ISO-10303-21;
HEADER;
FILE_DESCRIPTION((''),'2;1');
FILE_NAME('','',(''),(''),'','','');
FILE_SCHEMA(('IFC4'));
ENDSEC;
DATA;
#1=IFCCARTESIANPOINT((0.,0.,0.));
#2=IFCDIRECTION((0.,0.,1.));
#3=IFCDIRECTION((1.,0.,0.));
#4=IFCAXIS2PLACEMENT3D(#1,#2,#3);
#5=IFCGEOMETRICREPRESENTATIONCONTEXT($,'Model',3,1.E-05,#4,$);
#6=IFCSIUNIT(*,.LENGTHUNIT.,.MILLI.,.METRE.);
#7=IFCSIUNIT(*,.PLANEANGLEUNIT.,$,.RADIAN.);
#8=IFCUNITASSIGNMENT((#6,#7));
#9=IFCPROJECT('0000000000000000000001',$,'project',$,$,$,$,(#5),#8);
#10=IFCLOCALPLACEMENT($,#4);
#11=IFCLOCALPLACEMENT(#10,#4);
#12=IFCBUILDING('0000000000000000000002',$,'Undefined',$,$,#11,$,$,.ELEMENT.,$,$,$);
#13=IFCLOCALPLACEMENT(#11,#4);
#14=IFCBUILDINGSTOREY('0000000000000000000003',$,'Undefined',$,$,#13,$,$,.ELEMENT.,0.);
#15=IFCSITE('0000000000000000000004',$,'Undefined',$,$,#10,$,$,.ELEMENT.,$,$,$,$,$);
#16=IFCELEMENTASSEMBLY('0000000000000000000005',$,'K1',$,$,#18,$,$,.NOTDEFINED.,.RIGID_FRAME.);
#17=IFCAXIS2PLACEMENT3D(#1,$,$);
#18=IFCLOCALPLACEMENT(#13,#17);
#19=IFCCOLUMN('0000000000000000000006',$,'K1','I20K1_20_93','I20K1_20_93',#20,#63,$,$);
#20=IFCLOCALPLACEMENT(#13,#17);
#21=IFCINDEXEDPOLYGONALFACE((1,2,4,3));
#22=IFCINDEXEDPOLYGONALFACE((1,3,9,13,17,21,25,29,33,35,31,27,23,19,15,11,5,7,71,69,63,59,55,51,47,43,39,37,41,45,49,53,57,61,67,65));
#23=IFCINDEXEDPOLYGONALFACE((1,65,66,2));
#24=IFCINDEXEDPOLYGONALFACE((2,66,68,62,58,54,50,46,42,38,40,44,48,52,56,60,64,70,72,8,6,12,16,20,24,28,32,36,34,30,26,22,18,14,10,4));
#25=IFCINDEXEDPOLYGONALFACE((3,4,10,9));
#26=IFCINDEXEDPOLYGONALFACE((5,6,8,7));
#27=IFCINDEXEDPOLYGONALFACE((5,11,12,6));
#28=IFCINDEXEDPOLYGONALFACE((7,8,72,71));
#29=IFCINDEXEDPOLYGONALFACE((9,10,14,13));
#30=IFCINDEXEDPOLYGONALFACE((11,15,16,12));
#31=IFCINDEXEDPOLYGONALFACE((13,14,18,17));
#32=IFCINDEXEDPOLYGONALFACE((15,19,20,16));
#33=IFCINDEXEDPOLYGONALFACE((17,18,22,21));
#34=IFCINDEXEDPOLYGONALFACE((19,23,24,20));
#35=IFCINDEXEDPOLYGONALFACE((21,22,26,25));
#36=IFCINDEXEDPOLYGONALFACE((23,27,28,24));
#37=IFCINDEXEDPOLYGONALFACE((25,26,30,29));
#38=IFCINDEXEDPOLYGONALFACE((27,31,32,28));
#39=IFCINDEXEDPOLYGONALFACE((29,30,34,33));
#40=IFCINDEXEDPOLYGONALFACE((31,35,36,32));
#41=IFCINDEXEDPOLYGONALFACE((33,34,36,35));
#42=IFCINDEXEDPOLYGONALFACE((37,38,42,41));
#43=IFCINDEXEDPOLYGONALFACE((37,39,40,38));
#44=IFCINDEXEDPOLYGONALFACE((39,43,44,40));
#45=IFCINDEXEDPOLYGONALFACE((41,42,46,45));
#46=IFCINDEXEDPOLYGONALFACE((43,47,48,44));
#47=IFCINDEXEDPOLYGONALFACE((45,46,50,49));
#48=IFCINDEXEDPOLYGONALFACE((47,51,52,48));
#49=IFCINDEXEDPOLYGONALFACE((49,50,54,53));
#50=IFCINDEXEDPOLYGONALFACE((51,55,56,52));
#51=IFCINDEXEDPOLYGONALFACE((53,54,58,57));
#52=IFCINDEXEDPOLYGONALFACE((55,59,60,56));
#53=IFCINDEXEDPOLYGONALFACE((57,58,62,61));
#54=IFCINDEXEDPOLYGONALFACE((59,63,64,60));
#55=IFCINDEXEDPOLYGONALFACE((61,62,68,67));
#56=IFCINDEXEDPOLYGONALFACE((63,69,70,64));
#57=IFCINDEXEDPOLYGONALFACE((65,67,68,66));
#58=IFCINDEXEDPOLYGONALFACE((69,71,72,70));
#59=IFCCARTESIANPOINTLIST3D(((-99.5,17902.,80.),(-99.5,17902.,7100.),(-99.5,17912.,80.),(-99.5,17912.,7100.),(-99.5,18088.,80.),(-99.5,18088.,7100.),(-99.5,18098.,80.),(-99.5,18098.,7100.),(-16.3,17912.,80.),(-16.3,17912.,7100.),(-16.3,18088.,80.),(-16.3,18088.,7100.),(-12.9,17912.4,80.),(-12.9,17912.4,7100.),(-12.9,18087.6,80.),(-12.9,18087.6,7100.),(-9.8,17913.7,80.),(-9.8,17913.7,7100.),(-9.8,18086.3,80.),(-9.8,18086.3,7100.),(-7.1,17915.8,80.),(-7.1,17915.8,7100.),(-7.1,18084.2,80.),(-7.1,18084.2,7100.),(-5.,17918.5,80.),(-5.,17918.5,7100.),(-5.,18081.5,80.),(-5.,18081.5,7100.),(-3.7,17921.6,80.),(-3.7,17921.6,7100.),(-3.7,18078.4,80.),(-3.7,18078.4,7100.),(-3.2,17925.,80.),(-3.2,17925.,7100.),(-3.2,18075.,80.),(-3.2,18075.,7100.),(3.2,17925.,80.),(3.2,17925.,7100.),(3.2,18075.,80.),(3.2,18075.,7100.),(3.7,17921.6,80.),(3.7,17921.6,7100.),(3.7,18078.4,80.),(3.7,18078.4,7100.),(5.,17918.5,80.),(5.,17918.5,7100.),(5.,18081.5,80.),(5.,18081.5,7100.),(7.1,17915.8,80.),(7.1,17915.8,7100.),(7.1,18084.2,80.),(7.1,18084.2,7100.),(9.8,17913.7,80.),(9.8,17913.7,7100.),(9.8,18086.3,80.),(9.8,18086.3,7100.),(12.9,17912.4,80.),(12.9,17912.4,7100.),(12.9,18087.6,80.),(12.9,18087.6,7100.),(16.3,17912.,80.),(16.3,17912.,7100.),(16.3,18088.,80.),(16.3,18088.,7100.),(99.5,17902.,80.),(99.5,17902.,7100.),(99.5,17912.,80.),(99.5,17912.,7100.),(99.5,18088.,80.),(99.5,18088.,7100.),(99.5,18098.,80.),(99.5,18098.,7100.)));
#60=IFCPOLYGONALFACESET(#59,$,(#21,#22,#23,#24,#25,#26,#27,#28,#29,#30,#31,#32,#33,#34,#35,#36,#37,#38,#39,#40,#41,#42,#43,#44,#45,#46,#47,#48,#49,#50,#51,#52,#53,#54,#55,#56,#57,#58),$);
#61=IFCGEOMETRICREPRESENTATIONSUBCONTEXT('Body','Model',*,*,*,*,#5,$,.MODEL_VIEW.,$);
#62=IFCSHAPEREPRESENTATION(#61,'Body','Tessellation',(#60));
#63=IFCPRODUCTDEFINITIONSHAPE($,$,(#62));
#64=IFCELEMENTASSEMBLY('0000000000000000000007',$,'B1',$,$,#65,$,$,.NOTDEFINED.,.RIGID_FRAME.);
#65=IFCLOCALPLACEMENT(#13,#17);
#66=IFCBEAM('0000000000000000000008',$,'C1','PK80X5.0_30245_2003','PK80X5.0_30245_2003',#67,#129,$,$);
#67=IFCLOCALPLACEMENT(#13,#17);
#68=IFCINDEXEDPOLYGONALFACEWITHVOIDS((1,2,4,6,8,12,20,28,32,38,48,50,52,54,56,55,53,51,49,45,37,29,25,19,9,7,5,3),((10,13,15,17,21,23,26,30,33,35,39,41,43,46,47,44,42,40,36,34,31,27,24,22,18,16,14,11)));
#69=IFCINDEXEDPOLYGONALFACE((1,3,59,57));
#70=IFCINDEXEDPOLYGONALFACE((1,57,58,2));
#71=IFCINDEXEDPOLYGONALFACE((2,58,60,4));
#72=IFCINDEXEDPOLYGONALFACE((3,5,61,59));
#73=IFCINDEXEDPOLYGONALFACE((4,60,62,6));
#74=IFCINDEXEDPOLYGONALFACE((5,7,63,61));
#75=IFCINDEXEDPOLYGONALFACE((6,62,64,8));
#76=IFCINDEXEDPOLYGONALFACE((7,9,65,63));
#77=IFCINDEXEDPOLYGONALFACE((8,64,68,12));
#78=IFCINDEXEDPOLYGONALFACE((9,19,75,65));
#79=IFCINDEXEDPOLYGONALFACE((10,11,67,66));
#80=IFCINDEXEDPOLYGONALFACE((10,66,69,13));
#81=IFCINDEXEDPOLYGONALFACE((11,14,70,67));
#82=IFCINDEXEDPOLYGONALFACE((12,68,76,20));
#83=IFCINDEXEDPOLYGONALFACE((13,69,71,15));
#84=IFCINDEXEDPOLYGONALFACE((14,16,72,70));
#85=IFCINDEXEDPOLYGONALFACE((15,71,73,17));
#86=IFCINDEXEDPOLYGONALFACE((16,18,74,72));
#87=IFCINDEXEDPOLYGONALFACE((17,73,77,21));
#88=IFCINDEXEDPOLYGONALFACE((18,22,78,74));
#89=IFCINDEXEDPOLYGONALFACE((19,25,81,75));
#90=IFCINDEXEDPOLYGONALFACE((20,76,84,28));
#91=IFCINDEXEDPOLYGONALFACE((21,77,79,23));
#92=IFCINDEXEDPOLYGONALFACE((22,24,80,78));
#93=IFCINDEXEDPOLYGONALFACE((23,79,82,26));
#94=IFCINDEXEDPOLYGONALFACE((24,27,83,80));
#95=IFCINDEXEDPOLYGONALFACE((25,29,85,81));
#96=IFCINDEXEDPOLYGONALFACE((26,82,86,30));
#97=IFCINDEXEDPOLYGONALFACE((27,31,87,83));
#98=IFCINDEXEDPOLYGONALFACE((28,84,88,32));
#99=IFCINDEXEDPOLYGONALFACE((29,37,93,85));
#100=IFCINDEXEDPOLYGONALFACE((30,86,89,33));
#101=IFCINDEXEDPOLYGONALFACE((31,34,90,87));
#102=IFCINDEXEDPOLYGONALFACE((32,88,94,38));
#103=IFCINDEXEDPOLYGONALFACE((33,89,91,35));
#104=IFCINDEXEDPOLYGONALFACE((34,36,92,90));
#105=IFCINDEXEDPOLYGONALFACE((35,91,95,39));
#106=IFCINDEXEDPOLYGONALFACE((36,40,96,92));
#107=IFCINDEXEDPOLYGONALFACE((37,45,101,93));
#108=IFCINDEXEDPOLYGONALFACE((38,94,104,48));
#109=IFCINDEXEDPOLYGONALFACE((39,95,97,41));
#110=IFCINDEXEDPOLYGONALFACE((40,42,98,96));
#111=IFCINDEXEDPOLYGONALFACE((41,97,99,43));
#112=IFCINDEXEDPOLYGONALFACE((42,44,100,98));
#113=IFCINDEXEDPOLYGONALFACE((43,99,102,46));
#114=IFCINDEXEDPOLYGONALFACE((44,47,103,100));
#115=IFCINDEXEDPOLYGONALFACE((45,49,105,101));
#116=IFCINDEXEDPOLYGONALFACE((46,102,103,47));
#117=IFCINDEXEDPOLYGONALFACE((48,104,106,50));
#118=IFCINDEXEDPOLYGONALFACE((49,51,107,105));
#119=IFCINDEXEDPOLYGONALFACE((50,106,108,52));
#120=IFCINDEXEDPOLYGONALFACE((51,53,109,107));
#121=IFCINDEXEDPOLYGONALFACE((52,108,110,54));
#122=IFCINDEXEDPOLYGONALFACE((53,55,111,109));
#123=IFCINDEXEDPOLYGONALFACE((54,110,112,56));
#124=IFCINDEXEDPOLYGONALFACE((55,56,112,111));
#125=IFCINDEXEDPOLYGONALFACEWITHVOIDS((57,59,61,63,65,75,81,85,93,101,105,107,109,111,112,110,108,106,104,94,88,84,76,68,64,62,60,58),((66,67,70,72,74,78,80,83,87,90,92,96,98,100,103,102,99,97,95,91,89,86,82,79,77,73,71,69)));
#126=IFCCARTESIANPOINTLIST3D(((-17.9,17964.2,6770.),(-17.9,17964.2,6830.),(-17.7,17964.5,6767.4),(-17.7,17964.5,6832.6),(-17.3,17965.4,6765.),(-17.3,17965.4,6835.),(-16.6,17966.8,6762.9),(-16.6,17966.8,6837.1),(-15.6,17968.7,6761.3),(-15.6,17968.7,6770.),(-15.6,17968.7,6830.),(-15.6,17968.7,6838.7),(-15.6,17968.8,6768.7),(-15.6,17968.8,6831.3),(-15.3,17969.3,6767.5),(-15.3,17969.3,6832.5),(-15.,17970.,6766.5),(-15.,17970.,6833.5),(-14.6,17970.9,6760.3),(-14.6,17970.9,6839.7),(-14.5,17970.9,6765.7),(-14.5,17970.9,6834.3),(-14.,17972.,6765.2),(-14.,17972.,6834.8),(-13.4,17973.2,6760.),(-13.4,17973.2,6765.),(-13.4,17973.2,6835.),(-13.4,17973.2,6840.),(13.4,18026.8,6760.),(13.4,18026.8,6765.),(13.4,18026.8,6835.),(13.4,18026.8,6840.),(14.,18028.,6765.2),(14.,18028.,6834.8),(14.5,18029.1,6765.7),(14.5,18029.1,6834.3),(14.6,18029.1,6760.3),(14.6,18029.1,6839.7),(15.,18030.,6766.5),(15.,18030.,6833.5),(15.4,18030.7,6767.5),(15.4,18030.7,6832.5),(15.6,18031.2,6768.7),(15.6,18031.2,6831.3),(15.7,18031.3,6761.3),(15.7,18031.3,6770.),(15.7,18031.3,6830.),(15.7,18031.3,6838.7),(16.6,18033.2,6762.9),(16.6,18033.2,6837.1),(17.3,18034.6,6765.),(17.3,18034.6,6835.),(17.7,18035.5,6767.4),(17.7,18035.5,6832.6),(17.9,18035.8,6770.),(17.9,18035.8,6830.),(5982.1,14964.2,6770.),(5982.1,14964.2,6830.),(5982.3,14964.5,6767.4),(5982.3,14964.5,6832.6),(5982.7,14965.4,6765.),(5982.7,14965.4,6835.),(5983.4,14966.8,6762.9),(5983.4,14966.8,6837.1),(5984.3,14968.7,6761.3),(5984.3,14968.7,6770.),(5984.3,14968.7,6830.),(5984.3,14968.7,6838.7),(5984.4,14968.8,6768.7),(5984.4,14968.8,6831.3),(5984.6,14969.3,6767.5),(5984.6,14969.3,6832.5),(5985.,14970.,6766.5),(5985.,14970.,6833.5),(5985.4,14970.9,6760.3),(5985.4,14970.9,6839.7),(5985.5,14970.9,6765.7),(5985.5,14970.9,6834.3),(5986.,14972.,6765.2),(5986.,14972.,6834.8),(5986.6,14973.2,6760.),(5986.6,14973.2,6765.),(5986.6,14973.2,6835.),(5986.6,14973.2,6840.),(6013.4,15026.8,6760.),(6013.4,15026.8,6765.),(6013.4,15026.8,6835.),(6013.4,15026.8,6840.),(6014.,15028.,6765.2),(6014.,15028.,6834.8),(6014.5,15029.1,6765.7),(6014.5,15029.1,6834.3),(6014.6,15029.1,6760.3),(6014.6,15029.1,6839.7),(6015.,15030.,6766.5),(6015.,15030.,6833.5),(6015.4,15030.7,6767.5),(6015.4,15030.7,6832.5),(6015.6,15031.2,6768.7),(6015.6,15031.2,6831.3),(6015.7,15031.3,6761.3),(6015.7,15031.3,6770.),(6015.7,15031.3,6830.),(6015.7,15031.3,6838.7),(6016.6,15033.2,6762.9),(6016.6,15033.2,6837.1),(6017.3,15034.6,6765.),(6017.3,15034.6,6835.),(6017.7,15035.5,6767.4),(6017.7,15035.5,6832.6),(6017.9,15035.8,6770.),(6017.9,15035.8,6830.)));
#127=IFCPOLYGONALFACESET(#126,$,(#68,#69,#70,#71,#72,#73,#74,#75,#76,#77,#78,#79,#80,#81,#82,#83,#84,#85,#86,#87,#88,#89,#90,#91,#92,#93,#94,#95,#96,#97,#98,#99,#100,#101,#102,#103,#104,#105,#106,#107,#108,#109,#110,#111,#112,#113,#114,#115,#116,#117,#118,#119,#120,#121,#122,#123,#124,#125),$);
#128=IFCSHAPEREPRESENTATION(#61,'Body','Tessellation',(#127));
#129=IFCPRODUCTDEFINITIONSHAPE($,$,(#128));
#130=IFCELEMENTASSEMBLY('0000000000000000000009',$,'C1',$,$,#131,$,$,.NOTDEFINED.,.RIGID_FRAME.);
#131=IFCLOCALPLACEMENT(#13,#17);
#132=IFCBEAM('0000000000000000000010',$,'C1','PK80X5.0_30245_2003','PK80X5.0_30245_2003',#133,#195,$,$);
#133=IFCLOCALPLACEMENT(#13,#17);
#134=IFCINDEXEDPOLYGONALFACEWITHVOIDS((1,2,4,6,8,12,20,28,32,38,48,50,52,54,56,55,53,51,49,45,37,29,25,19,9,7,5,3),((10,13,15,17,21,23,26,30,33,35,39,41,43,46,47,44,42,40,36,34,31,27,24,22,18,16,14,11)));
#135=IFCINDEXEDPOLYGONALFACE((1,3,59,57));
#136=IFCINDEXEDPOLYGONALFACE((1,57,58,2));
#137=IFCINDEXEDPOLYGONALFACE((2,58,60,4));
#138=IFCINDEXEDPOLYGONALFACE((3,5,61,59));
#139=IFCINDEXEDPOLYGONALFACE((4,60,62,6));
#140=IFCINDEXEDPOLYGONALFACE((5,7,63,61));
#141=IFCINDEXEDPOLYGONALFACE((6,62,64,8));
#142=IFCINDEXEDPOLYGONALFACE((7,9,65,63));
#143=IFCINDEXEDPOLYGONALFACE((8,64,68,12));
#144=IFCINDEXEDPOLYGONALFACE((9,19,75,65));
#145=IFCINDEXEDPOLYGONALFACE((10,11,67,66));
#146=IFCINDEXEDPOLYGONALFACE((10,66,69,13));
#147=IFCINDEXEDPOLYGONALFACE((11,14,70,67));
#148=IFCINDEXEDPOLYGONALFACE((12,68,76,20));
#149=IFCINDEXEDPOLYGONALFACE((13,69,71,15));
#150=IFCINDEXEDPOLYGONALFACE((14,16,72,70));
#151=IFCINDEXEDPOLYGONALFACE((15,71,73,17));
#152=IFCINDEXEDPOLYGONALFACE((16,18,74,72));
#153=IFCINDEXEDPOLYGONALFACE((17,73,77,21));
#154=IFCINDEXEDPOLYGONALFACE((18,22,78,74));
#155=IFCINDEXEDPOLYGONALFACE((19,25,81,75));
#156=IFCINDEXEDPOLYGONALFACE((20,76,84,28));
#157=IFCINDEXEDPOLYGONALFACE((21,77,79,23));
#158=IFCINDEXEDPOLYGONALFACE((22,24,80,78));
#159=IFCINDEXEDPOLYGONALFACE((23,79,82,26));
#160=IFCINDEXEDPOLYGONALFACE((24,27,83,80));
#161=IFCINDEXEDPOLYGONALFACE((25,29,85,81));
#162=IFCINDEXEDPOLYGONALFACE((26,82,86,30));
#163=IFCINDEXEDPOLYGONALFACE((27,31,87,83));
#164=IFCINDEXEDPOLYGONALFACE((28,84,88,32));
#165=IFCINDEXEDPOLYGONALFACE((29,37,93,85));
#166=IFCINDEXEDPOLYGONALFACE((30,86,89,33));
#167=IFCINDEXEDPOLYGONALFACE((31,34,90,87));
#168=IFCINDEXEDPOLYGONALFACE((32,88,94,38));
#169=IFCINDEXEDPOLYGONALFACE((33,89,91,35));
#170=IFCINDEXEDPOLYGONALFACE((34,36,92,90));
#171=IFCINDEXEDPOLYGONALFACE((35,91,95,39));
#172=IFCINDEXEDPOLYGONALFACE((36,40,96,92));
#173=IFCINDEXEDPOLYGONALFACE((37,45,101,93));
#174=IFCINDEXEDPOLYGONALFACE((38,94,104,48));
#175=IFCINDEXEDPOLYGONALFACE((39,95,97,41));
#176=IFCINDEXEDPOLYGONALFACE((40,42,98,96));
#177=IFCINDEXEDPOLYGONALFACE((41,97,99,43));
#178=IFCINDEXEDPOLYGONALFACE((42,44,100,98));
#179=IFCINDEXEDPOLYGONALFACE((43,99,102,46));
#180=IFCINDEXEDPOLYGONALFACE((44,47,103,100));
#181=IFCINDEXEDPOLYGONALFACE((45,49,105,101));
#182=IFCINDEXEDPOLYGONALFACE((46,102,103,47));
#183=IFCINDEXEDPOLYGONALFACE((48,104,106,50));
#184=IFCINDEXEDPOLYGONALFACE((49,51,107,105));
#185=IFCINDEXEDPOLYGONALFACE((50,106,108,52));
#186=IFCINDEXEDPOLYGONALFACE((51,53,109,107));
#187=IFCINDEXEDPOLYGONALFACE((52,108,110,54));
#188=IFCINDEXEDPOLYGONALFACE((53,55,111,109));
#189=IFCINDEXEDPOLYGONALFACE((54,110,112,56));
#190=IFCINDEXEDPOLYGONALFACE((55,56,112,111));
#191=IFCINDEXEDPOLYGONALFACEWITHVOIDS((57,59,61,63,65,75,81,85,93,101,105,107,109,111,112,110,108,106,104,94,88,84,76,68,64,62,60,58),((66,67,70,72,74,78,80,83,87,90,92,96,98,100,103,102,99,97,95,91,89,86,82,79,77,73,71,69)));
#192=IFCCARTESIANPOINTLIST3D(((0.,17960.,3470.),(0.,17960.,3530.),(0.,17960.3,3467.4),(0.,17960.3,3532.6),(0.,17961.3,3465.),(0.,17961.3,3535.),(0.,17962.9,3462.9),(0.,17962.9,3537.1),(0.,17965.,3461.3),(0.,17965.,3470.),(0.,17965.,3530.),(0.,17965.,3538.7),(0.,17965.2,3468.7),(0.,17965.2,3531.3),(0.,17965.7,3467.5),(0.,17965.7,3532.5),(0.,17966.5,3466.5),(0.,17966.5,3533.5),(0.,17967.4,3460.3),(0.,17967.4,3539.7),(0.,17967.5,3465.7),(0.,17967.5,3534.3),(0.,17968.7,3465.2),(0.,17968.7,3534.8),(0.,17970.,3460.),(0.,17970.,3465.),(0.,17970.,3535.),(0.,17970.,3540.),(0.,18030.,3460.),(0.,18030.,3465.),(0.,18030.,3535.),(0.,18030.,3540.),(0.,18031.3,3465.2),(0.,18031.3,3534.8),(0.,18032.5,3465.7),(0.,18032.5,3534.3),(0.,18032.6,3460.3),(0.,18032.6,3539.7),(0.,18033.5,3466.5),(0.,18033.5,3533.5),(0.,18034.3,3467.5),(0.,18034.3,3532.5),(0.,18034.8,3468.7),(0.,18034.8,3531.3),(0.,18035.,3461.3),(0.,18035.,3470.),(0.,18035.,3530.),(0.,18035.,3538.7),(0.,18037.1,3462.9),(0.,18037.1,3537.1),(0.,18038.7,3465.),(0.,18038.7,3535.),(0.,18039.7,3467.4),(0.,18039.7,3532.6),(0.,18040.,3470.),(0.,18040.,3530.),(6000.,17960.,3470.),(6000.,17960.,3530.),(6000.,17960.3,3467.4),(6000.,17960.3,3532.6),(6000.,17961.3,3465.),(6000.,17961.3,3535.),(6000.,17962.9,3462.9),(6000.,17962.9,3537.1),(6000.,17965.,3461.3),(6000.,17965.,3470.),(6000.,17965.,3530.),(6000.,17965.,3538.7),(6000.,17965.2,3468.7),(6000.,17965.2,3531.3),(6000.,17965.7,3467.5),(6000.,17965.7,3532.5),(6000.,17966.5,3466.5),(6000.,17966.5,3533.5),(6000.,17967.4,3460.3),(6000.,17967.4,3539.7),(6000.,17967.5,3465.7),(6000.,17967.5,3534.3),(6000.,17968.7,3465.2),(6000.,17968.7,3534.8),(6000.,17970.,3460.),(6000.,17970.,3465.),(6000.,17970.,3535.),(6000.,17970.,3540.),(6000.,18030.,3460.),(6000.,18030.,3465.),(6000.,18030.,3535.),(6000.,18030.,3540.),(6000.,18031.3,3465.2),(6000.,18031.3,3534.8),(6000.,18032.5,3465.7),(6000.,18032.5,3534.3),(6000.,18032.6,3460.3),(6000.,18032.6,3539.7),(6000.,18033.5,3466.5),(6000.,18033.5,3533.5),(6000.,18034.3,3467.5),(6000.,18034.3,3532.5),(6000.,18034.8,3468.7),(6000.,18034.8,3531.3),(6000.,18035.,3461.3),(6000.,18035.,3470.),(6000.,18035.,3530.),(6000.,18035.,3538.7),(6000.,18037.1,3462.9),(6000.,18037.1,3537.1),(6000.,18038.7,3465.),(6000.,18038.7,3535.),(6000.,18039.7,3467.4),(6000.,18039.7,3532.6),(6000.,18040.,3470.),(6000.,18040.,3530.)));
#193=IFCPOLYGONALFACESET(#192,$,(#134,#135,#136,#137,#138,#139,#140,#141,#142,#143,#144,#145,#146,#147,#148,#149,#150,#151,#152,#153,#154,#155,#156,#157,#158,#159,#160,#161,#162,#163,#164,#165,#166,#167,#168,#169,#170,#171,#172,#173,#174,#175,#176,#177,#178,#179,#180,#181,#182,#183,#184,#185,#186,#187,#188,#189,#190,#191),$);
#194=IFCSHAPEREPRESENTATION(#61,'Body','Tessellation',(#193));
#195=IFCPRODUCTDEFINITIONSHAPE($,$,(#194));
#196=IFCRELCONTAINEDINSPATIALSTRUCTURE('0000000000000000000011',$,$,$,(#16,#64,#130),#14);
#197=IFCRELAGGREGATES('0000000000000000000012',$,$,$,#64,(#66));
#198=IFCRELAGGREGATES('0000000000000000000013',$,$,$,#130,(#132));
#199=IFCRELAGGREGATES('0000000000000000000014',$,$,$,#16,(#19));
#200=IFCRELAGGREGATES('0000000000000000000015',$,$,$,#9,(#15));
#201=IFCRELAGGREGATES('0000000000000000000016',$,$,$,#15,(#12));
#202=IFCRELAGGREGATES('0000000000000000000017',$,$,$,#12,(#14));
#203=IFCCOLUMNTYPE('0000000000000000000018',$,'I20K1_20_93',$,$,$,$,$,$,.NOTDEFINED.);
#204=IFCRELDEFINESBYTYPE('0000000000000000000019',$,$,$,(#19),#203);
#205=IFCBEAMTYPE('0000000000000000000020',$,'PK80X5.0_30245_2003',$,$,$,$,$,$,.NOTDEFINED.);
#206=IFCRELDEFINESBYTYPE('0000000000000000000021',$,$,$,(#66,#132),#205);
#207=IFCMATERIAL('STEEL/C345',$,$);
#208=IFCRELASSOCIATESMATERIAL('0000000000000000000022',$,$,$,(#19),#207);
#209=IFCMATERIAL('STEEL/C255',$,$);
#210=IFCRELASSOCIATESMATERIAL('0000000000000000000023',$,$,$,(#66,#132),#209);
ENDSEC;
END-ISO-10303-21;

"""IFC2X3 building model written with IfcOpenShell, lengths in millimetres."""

from ifc_helpers import new_model, si_unit, frame, origin_with_axes, origin_2d_with_axis, place, context, subcontext, project, spatial, hollow_rectangle, i_section, extrude, material, type_object, element, aggregate, save


model = new_model("IFC2X3")

# Units and contexts
model_context = context("Model", 3, precision=1e-05, world=origin_with_axes())
body_context = subcontext(model_context, "Body", "Model", "MODEL_VIEW")
ifc_project = project(units=[si_unit("LENGTHUNIT", "METRE", prefix="MILLI"), si_unit("PLANEANGLEUNIT", "RADIAN")], contexts=[model_context])

# Site, building, storey
site_placement = place(None, origin_with_axes())
site = spatial("IfcSite", under=ifc_project, at=site_placement, Name="Undefined", CompositionType="ELEMENT")
building_placement = place(site_placement, origin_with_axes())
building = spatial("IfcBuilding", under=site, at=building_placement, Name="Undefined", CompositionType="ELEMENT")
storey_placement = place(building_placement, origin_with_axes())
storey = spatial("IfcBuildingStorey", under=building, at=storey_placement, Name="Undefined", CompositionType="ELEMENT", Elevation=0.0)

# Element assembly, column
assembly_1_placement = place(storey_placement, origin_with_axes())
assembly_1 = element("IfcElementAssembly", 1, at=assembly_1_placement, inside=storey, Name="K1", AssemblyPlace="NOTDEFINED", PredefinedType="RIGID_FRAME")
ifc_material_1 = material(Name="STEEL/C345")
column_type_1 = type_object("IfcColumnType", Name="I20K1_20_93", PredefinedType="NOTDEFINED")
column_1_placement = place(assembly_1_placement, frame((0.0, 18000.0, 80.0), z_axis=(0.0, 0.0, 1.0), x_axis=(0.0, 1.0, 0.0)))
column_1 = element("IfcColumn", 2, at=column_1_placement, type_object=column_type_1, material=ifc_material_1, Name="K1", Description="I20K1_20_93", ObjectType="I20K1_20_93", context=body_context, shape_type="SweptSolid", body=[
    extrude(i_section(OverallWidth=199.0, OverallDepth=196.0, WebThickness=6.5, FlangeThickness=10.0, FilletRadius=13.0, at=origin_2d_with_axis()), frame((0.0, 0.0, 7020.0), z_axis=(0.0, 0.0, -1.0), x_axis=(0.0, 1.0, 0.0)), (0.0, 0.0, 1.0), 7020.0),
])

# Element assemblies, beams
assembly_2_placement = place(storey_placement, origin_with_axes())
assembly_2 = element("IfcElementAssembly", 3, at=assembly_2_placement, inside=storey, Name="B1", AssemblyPlace="NOTDEFINED", PredefinedType="RIGID_FRAME")
ifc_material_2 = material(Name="STEEL/C255")
beam_type_1 = type_object("IfcBeamType", Name="PK80X5.0_30245_2003", PredefinedType="NOTDEFINED")
beam_1_placement = place(assembly_2_placement, frame((0.0, 18000.0, 6800.0), z_axis=(0.0, 0.0, -1.0), x_axis=(0.894427, -0.447214, 0.0)))
beam_1 = element("IfcBeam", 4, at=beam_1_placement, type_object=beam_type_1, material=ifc_material_2, Name="C1", Description="PK80X5.0_30245_2003", ObjectType="PK80X5.0_30245_2003", context=body_context, shape_type="SweptSolid", body=[
    extrude(hollow_rectangle(XDim=80.0, YDim=80.0, WallThickness=5.0, InnerFilletRadius=5.0, OuterFilletRadius=10.0, at=origin_2d_with_axis()), frame((6708.2, 0.0, 0.0), z_axis=(-1.0, 0.0, 0.0), x_axis=(0.0, -1.0, 0.0)), (0.0, 0.0, 1.0), 6708.2),
])
aggregate(assembly_2, [beam_1])
assembly_3_placement = place(storey_placement, origin_with_axes())
assembly_3 = element("IfcElementAssembly", 5, at=assembly_3_placement, inside=storey, Name="C1", AssemblyPlace="NOTDEFINED", PredefinedType="RIGID_FRAME")
beam_2_placement = place(assembly_3_placement, frame((0.0, 18000.0, 3500.0), z_axis=(0.0, 0.0, -1.0), x_axis=(1.0, 0.0, 0.0)))
beam_2 = element("IfcBeam", 6, at=beam_2_placement, type_object=beam_type_1, material=ifc_material_2, Name="C1", Description="PK80X5.0_30245_2003", ObjectType="PK80X5.0_30245_2003", context=body_context, shape_type="SweptSolid", body=[
    extrude(hollow_rectangle(XDim=80.0, YDim=80.0, WallThickness=5.0, InnerFilletRadius=5.0, OuterFilletRadius=10.0, at=origin_2d_with_axis()), frame((6000.0, 0.0, 0.0), z_axis=(-1.0, 0.0, 0.0), x_axis=(0.0, -1.0, 0.0)), (0.0, 0.0, 1.0), 6000.0),
])
aggregate(assembly_3, [beam_2])

aggregate(assembly_1, [column_1])

save(model, "model.ifc")
